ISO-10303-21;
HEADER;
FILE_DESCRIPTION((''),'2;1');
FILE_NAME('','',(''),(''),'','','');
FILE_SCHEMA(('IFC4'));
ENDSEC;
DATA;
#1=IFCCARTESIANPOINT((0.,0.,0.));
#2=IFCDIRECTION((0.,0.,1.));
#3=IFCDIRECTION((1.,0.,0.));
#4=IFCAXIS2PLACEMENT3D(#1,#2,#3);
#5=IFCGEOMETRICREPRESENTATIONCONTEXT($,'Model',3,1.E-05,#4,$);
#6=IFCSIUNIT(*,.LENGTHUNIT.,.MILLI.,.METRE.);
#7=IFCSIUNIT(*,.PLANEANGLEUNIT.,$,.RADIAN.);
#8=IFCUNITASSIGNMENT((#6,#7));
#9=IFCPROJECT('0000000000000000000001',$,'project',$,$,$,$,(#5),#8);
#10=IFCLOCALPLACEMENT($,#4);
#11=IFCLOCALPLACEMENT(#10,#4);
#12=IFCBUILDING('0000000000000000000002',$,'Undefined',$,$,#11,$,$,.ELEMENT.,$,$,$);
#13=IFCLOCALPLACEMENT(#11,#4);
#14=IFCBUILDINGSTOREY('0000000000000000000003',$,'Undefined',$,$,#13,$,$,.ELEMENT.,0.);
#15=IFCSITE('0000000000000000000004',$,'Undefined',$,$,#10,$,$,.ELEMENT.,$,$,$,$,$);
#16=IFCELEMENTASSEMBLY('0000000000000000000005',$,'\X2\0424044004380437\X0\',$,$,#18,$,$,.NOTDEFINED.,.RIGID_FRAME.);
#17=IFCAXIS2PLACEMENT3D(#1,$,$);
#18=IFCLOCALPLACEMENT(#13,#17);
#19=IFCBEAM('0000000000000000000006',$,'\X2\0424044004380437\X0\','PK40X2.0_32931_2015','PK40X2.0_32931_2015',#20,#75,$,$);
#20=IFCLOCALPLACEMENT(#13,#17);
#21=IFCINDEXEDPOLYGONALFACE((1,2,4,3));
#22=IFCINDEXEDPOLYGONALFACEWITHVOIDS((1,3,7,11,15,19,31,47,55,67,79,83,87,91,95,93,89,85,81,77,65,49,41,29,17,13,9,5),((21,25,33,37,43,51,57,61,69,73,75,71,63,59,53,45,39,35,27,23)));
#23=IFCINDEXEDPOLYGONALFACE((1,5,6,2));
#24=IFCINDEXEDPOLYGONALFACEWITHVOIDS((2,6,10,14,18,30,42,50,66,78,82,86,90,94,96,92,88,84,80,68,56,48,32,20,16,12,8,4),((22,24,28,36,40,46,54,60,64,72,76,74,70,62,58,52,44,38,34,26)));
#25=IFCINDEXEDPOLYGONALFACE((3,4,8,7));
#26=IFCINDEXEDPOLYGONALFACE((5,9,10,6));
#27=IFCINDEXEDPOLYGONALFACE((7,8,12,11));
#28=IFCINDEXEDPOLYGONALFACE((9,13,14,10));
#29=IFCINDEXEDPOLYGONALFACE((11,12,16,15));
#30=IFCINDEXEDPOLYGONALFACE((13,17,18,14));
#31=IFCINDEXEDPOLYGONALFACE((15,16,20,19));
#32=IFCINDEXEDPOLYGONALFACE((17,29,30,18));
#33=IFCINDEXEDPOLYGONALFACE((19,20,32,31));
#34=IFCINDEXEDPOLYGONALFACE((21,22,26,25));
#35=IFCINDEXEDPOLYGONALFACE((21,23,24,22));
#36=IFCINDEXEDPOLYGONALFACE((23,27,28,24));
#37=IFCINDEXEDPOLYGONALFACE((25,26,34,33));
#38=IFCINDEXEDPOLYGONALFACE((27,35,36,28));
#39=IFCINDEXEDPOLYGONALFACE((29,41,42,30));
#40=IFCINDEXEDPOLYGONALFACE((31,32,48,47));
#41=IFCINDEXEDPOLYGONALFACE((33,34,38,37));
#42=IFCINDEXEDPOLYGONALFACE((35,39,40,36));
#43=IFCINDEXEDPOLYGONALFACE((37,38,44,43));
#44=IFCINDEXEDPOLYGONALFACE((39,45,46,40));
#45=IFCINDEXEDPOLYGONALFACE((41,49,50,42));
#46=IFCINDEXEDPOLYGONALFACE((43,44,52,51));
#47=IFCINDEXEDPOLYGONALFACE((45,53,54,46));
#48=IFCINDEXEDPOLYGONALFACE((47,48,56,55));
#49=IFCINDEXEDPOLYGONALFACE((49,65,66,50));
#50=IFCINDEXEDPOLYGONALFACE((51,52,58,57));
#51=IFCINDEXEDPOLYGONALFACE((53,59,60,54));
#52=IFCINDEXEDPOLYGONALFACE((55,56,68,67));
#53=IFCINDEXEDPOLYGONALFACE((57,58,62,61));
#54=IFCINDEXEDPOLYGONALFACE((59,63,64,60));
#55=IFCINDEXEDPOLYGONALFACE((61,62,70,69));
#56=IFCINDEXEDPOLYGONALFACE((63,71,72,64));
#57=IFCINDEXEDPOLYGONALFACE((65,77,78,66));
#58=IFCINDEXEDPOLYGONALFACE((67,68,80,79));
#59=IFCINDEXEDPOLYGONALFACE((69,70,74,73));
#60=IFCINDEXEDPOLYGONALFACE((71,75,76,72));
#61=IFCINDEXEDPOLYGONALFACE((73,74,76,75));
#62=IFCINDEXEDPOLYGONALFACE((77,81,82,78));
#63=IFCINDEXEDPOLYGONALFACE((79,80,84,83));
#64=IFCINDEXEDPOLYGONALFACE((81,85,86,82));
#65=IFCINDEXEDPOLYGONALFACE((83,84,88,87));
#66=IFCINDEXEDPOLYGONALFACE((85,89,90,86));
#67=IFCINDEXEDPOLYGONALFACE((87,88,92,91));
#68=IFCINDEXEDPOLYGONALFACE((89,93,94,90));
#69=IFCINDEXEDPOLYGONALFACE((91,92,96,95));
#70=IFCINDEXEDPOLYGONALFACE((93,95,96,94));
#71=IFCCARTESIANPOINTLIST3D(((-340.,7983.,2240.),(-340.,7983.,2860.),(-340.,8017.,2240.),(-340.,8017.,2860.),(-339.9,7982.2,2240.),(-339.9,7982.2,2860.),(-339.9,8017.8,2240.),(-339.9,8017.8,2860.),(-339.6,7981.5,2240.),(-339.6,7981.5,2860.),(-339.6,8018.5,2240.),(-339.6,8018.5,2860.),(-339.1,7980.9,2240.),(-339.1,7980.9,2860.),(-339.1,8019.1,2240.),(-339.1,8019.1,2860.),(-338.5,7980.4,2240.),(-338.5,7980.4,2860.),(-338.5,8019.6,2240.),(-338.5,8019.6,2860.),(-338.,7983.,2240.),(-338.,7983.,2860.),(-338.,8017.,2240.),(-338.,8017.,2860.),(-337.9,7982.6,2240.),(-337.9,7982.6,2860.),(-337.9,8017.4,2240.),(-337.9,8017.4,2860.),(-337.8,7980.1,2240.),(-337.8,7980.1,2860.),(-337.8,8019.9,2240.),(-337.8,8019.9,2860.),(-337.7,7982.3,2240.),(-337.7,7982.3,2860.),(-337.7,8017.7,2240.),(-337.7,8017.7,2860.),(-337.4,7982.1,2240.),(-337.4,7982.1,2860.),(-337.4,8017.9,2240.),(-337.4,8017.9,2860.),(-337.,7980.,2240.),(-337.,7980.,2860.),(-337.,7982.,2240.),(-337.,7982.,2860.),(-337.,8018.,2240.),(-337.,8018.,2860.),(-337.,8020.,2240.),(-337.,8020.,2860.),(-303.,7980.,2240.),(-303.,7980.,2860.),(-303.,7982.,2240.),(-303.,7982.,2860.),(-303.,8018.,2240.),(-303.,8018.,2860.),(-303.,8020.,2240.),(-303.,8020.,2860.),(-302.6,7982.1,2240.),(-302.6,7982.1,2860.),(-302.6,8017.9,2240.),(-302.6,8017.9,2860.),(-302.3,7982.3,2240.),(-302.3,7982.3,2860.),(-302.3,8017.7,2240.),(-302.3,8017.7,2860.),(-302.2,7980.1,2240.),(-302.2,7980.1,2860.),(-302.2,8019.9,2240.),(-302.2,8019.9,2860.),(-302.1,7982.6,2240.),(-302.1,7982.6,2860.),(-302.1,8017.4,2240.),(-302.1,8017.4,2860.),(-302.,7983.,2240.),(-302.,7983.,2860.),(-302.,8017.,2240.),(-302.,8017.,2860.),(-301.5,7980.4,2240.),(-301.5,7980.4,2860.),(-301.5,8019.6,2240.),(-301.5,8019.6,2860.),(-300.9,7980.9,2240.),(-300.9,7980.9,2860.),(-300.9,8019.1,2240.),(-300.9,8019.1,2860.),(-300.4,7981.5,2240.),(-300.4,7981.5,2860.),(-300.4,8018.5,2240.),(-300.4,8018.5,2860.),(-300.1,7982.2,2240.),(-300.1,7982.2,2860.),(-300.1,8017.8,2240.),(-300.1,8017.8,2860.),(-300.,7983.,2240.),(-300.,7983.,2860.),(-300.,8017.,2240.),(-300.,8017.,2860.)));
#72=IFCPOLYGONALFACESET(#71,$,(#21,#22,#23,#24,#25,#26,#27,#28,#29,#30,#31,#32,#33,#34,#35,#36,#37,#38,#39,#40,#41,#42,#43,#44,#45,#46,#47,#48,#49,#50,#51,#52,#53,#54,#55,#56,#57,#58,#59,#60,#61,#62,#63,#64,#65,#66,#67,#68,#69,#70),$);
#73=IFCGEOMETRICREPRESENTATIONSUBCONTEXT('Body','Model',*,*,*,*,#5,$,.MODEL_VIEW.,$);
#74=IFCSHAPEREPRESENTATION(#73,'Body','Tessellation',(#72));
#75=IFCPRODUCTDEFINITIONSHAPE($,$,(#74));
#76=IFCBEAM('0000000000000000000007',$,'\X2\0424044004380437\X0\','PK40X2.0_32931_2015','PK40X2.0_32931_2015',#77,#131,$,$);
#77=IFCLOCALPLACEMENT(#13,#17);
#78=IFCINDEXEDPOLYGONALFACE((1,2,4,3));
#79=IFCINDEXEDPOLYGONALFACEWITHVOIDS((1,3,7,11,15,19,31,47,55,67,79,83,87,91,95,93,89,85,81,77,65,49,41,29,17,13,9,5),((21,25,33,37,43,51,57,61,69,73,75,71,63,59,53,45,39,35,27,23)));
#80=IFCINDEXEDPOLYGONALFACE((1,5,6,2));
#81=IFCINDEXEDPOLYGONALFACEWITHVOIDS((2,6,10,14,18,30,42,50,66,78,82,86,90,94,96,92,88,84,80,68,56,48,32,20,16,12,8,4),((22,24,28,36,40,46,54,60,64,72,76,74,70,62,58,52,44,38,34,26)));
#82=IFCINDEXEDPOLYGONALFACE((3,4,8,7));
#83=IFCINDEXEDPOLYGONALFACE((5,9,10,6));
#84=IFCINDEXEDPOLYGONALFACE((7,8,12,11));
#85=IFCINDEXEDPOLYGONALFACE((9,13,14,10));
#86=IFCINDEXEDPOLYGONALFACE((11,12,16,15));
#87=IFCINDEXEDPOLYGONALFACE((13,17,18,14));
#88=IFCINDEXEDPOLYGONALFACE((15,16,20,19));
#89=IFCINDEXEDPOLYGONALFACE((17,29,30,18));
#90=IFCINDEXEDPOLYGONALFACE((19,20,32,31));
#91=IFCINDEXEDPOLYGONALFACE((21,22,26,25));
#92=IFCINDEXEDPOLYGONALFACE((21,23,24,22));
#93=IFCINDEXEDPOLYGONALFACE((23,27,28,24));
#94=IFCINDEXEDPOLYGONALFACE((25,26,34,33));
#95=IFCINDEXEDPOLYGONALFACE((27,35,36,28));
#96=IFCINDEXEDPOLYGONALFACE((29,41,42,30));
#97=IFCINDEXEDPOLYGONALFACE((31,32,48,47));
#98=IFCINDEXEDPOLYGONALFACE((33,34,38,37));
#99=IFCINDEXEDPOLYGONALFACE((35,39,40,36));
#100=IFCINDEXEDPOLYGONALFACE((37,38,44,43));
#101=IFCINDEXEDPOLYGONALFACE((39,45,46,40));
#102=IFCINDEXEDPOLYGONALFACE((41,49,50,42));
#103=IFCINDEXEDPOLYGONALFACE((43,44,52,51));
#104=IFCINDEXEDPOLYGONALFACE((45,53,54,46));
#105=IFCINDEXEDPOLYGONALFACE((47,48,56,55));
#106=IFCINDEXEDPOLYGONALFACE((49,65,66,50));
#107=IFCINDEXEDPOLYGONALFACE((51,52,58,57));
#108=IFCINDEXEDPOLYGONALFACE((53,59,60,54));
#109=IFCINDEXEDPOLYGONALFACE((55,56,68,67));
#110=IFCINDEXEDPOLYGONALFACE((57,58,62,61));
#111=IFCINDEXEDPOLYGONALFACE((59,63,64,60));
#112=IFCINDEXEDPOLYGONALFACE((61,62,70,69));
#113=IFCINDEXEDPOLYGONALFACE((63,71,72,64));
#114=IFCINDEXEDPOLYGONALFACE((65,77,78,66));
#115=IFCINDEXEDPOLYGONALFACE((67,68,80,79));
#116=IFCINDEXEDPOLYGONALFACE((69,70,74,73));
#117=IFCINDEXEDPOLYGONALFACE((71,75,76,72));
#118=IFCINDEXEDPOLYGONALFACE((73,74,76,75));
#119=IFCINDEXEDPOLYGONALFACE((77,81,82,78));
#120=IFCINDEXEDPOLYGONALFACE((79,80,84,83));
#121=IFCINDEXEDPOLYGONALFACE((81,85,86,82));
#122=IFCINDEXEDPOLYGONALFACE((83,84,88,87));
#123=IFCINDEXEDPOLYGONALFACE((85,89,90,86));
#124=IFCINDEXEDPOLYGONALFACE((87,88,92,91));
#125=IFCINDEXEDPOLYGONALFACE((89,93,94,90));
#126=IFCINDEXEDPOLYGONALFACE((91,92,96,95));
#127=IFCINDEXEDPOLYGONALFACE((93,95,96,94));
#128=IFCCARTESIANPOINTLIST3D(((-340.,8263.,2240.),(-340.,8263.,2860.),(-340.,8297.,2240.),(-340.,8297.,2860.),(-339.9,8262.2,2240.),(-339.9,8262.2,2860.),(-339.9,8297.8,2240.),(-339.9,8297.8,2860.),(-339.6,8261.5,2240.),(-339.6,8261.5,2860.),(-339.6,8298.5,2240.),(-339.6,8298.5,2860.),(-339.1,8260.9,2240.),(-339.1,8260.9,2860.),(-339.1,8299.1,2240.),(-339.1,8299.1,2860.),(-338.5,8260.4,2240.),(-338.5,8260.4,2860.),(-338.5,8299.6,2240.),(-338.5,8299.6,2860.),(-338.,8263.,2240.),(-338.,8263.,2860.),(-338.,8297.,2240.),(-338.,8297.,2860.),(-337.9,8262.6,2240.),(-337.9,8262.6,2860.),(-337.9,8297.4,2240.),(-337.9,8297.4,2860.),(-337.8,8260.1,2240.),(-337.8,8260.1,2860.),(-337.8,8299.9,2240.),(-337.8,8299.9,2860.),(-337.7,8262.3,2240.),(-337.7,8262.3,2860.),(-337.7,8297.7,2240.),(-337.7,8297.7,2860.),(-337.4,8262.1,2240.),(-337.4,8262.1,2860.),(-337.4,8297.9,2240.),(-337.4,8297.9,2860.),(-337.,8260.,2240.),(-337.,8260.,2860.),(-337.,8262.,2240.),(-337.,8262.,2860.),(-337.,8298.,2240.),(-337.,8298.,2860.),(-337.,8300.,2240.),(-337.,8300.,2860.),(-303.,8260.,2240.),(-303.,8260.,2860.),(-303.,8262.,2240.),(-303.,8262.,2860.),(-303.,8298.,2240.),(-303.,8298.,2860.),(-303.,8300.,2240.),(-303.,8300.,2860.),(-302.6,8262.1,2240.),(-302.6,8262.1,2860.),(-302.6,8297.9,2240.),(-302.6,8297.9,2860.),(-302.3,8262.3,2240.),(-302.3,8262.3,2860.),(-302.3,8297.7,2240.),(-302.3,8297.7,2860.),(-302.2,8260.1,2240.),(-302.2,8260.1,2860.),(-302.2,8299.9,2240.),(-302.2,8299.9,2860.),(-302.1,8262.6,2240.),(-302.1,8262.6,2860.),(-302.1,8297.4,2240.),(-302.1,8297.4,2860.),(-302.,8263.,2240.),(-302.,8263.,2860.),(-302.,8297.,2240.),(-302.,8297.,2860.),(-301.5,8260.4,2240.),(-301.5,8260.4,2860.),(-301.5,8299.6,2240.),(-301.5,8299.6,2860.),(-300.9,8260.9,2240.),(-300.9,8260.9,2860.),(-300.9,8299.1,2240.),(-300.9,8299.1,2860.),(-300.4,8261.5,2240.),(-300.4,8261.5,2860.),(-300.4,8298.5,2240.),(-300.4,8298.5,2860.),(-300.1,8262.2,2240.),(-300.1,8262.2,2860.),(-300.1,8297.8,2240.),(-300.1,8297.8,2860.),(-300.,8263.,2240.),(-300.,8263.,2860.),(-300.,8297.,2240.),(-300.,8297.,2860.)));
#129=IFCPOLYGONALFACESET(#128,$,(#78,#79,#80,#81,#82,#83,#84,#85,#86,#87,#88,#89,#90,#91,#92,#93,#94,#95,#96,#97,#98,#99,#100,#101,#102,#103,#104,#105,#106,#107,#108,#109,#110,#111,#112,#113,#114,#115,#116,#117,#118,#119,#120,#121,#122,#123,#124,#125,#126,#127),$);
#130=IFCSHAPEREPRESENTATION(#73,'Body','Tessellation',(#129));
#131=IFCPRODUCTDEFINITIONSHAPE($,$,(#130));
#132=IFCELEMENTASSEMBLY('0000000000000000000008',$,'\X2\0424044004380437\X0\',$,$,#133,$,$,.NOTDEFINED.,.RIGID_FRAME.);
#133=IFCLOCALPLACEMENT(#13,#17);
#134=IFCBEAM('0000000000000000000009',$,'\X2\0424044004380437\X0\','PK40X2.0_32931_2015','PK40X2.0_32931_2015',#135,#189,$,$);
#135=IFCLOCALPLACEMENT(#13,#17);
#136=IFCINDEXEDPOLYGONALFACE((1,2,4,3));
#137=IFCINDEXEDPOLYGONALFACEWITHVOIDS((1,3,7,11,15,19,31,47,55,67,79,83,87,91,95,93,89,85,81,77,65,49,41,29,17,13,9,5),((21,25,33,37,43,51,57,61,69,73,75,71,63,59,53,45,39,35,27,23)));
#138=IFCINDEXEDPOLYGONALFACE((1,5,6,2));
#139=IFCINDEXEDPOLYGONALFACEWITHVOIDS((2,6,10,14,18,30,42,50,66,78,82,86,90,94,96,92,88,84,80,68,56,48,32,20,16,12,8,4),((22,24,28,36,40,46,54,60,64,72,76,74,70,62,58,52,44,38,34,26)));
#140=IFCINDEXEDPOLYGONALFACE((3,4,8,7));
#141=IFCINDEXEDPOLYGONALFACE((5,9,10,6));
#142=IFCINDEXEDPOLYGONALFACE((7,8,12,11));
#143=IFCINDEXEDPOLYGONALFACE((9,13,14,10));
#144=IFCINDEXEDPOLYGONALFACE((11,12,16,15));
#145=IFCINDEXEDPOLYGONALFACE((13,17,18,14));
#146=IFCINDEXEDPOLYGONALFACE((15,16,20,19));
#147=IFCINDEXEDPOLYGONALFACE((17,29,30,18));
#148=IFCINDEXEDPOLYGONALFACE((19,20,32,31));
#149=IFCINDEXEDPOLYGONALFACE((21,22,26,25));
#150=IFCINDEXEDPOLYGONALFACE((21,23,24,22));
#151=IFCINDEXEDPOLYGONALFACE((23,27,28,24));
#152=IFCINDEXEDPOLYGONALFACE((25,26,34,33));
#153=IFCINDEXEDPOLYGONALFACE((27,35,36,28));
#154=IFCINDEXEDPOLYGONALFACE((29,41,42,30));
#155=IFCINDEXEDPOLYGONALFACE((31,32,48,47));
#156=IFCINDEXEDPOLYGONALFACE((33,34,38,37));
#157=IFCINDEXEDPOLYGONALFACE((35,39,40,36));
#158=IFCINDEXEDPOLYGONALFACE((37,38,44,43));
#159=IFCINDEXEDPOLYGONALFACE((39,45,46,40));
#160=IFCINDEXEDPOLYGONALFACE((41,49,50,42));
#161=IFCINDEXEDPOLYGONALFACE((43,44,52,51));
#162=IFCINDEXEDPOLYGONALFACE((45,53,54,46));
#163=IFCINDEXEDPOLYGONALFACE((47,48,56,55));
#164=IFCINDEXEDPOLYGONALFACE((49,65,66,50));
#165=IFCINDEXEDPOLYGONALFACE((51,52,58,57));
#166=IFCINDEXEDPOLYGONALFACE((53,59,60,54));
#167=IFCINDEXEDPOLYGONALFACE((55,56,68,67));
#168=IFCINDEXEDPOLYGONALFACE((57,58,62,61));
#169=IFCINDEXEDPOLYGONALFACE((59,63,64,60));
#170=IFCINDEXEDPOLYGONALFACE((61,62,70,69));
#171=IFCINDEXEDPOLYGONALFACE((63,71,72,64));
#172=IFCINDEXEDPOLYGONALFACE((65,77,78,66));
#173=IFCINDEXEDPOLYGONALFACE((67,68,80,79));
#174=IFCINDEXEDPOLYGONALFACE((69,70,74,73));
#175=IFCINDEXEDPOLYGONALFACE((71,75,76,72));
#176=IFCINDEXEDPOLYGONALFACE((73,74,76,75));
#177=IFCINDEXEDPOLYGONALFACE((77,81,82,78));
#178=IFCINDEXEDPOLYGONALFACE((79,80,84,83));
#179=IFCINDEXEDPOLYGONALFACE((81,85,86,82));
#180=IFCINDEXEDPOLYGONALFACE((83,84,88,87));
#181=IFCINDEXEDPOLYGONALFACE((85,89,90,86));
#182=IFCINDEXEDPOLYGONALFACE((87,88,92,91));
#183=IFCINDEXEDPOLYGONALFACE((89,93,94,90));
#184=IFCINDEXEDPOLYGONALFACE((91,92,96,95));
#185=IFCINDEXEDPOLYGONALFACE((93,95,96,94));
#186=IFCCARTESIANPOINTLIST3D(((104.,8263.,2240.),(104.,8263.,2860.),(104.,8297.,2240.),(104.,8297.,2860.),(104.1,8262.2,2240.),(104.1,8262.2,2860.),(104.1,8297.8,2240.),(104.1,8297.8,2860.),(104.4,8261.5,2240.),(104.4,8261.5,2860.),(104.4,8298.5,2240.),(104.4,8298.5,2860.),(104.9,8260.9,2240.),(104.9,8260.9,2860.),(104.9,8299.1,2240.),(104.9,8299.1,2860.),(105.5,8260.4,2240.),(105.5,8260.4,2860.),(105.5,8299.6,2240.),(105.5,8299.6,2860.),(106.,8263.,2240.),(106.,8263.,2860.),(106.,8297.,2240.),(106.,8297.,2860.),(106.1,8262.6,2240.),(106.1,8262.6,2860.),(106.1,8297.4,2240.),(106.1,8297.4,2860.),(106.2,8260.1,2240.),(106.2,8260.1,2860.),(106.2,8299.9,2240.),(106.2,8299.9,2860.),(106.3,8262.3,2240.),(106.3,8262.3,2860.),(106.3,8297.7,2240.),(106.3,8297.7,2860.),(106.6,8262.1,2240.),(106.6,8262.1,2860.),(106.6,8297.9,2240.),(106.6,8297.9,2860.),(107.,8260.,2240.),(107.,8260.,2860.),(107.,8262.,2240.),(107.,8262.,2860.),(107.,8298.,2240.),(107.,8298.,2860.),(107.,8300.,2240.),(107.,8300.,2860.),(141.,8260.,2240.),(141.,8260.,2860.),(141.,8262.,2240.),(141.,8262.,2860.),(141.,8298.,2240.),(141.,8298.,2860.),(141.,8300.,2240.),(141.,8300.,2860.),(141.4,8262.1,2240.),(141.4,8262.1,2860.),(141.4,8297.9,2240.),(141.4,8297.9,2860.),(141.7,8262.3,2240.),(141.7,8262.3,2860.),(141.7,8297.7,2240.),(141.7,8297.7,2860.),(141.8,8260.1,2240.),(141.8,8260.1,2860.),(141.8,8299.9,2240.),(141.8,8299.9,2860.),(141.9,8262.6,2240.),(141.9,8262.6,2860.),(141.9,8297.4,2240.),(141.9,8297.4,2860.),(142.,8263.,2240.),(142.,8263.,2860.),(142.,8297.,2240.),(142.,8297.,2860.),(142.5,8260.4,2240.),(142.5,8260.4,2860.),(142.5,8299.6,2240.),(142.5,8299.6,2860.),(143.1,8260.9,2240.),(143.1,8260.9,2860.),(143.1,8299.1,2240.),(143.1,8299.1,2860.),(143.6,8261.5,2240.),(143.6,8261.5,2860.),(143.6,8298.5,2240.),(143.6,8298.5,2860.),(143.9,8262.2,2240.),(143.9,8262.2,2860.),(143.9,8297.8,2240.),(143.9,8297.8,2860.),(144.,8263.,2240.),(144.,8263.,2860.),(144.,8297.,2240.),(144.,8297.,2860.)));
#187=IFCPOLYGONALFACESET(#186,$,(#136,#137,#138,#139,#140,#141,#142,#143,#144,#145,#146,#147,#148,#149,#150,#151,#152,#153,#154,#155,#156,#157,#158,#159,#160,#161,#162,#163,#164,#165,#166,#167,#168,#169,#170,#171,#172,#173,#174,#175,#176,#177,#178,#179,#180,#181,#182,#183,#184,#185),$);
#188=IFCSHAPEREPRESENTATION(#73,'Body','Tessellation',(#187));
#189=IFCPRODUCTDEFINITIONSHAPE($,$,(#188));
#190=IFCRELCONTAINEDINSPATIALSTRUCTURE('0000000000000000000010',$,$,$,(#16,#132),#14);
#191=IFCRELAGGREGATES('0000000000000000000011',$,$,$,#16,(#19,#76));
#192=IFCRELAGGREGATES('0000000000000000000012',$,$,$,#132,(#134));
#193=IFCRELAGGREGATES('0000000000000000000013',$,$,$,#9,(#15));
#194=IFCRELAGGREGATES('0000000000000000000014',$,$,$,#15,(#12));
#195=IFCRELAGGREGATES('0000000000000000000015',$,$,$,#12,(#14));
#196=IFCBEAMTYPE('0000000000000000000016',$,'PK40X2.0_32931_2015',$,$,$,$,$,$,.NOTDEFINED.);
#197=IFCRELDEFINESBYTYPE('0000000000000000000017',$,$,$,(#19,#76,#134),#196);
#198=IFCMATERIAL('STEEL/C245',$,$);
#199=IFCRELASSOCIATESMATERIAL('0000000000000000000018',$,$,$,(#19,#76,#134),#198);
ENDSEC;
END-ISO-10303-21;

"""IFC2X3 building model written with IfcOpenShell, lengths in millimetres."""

from ifc_helpers import new_model, si_unit, frame, origin_with_axes, origin_2d_with_axis, place, context, subcontext, project, spatial, hollow_rectangle, extrude, material, type_object, element, aggregate, save


model = new_model("IFC2X3")

# Units and contexts
model_context = context("Model", 3, precision=1e-05, world=origin_with_axes())
body_context = subcontext(model_context, "Body", "Model", "MODEL_VIEW")
ifc_project = project(units=[si_unit("LENGTHUNIT", "METRE", prefix="MILLI"), si_unit("PLANEANGLEUNIT", "RADIAN")], contexts=[model_context])

# Site, building, storey
site_placement = place(None, origin_with_axes())
site = spatial("IfcSite", under=ifc_project, at=site_placement, Name="Undefined", CompositionType="ELEMENT")
building_placement = place(site_placement, origin_with_axes())
building = spatial("IfcBuilding", under=site, at=building_placement, Name="Undefined", CompositionType="ELEMENT")
storey_placement = place(building_placement, origin_with_axes())
storey = spatial("IfcBuildingStorey", under=building, at=storey_placement, Name="Undefined", CompositionType="ELEMENT", Elevation=0.0)

# Shared definitions
ifc_material_1 = material(Name="STEEL/C245")

# Element assembly
assembly_1_placement = place(storey_placement, origin_with_axes())
assembly_1 = element("IfcElementAssembly", 1, at=assembly_1_placement, inside=storey, Name="Фриз", AssemblyPlace="NOTDEFINED", PredefinedType="RIGID_FRAME")

# Shared definitions
beam_type_1 = type_object("IfcBeamType", Name="PK40X2.0_32931_2015", PredefinedType="NOTDEFINED")

# Beams
beam_1_placement = place(assembly_1_placement, frame((-320.0, 8000.0, 2860.0), z_axis=(1.0, 0.0, 0.0), x_axis=(0.0, 0.0, -1.0)))
beam_1 = element("IfcBeam", 2, at=beam_1_placement, type_object=beam_type_1, material=ifc_material_1, Name="Фриз", Description="PK40X2.0_32931_2015", ObjectType="PK40X2.0_32931_2015", context=body_context, shape_type="SweptSolid", body=[
    extrude(hollow_rectangle(XDim=40.0, YDim=40.0, WallThickness=2.0, InnerFilletRadius=1.0, OuterFilletRadius=3.0, at=origin_2d_with_axis()), frame((620.0, 0.0, 0.0), z_axis=(-1.0, 0.0, 0.0), x_axis=(0.0, -1.0, 0.0)), (0.0, 0.0, 1.0), 620.0),
])
beam_2_placement = place(assembly_1_placement, frame((-320.0, 8280.0, 2860.0), z_axis=(1.0, 0.0, 0.0), x_axis=(0.0, 0.0, -1.0)))
beam_2 = element("IfcBeam", 3, at=beam_2_placement, type_object=beam_type_1, material=ifc_material_1, Name="Фриз", Description="PK40X2.0_32931_2015", ObjectType="PK40X2.0_32931_2015", context=body_context, shape_type="SweptSolid", body=[
    extrude(hollow_rectangle(XDim=40.0, YDim=40.0, WallThickness=2.0, InnerFilletRadius=1.0, OuterFilletRadius=3.0, at=origin_2d_with_axis()), frame((620.0, 0.0, 0.0), z_axis=(-1.0, 0.0, 0.0), x_axis=(0.0, -1.0, 0.0)), (0.0, 0.0, 1.0), 620.0),
])
aggregate(assembly_1, [beam_1, beam_2])

# Element assembly, beam
assembly_2_placement = place(storey_placement, origin_with_axes())
assembly_2 = element("IfcElementAssembly", 4, at=assembly_2_placement, inside=storey, Name="Фриз", AssemblyPlace="NOTDEFINED", PredefinedType="RIGID_FRAME")
beam_3_placement = place(assembly_2_placement, frame((124.0, 8280.0, 2860.0), z_axis=(1.0, 0.0, 0.0), x_axis=(0.0, 0.0, -1.0)))
beam_3 = element("IfcBeam", 5, at=beam_3_placement, type_object=beam_type_1, material=ifc_material_1, Name="Фриз", Description="PK40X2.0_32931_2015", ObjectType="PK40X2.0_32931_2015", context=body_context, shape_type="SweptSolid", body=[
    extrude(hollow_rectangle(XDim=40.0, YDim=40.0, WallThickness=2.0, InnerFilletRadius=1.0, OuterFilletRadius=3.0, at=origin_2d_with_axis()), frame((620.0, 0.0, 0.0), z_axis=(-1.0, 0.0, 0.0), x_axis=(0.0, -1.0, 0.0)), (0.0, 0.0, 1.0), 620.0),
])
aggregate(assembly_2, [beam_3])

save(model, "model.ifc")
